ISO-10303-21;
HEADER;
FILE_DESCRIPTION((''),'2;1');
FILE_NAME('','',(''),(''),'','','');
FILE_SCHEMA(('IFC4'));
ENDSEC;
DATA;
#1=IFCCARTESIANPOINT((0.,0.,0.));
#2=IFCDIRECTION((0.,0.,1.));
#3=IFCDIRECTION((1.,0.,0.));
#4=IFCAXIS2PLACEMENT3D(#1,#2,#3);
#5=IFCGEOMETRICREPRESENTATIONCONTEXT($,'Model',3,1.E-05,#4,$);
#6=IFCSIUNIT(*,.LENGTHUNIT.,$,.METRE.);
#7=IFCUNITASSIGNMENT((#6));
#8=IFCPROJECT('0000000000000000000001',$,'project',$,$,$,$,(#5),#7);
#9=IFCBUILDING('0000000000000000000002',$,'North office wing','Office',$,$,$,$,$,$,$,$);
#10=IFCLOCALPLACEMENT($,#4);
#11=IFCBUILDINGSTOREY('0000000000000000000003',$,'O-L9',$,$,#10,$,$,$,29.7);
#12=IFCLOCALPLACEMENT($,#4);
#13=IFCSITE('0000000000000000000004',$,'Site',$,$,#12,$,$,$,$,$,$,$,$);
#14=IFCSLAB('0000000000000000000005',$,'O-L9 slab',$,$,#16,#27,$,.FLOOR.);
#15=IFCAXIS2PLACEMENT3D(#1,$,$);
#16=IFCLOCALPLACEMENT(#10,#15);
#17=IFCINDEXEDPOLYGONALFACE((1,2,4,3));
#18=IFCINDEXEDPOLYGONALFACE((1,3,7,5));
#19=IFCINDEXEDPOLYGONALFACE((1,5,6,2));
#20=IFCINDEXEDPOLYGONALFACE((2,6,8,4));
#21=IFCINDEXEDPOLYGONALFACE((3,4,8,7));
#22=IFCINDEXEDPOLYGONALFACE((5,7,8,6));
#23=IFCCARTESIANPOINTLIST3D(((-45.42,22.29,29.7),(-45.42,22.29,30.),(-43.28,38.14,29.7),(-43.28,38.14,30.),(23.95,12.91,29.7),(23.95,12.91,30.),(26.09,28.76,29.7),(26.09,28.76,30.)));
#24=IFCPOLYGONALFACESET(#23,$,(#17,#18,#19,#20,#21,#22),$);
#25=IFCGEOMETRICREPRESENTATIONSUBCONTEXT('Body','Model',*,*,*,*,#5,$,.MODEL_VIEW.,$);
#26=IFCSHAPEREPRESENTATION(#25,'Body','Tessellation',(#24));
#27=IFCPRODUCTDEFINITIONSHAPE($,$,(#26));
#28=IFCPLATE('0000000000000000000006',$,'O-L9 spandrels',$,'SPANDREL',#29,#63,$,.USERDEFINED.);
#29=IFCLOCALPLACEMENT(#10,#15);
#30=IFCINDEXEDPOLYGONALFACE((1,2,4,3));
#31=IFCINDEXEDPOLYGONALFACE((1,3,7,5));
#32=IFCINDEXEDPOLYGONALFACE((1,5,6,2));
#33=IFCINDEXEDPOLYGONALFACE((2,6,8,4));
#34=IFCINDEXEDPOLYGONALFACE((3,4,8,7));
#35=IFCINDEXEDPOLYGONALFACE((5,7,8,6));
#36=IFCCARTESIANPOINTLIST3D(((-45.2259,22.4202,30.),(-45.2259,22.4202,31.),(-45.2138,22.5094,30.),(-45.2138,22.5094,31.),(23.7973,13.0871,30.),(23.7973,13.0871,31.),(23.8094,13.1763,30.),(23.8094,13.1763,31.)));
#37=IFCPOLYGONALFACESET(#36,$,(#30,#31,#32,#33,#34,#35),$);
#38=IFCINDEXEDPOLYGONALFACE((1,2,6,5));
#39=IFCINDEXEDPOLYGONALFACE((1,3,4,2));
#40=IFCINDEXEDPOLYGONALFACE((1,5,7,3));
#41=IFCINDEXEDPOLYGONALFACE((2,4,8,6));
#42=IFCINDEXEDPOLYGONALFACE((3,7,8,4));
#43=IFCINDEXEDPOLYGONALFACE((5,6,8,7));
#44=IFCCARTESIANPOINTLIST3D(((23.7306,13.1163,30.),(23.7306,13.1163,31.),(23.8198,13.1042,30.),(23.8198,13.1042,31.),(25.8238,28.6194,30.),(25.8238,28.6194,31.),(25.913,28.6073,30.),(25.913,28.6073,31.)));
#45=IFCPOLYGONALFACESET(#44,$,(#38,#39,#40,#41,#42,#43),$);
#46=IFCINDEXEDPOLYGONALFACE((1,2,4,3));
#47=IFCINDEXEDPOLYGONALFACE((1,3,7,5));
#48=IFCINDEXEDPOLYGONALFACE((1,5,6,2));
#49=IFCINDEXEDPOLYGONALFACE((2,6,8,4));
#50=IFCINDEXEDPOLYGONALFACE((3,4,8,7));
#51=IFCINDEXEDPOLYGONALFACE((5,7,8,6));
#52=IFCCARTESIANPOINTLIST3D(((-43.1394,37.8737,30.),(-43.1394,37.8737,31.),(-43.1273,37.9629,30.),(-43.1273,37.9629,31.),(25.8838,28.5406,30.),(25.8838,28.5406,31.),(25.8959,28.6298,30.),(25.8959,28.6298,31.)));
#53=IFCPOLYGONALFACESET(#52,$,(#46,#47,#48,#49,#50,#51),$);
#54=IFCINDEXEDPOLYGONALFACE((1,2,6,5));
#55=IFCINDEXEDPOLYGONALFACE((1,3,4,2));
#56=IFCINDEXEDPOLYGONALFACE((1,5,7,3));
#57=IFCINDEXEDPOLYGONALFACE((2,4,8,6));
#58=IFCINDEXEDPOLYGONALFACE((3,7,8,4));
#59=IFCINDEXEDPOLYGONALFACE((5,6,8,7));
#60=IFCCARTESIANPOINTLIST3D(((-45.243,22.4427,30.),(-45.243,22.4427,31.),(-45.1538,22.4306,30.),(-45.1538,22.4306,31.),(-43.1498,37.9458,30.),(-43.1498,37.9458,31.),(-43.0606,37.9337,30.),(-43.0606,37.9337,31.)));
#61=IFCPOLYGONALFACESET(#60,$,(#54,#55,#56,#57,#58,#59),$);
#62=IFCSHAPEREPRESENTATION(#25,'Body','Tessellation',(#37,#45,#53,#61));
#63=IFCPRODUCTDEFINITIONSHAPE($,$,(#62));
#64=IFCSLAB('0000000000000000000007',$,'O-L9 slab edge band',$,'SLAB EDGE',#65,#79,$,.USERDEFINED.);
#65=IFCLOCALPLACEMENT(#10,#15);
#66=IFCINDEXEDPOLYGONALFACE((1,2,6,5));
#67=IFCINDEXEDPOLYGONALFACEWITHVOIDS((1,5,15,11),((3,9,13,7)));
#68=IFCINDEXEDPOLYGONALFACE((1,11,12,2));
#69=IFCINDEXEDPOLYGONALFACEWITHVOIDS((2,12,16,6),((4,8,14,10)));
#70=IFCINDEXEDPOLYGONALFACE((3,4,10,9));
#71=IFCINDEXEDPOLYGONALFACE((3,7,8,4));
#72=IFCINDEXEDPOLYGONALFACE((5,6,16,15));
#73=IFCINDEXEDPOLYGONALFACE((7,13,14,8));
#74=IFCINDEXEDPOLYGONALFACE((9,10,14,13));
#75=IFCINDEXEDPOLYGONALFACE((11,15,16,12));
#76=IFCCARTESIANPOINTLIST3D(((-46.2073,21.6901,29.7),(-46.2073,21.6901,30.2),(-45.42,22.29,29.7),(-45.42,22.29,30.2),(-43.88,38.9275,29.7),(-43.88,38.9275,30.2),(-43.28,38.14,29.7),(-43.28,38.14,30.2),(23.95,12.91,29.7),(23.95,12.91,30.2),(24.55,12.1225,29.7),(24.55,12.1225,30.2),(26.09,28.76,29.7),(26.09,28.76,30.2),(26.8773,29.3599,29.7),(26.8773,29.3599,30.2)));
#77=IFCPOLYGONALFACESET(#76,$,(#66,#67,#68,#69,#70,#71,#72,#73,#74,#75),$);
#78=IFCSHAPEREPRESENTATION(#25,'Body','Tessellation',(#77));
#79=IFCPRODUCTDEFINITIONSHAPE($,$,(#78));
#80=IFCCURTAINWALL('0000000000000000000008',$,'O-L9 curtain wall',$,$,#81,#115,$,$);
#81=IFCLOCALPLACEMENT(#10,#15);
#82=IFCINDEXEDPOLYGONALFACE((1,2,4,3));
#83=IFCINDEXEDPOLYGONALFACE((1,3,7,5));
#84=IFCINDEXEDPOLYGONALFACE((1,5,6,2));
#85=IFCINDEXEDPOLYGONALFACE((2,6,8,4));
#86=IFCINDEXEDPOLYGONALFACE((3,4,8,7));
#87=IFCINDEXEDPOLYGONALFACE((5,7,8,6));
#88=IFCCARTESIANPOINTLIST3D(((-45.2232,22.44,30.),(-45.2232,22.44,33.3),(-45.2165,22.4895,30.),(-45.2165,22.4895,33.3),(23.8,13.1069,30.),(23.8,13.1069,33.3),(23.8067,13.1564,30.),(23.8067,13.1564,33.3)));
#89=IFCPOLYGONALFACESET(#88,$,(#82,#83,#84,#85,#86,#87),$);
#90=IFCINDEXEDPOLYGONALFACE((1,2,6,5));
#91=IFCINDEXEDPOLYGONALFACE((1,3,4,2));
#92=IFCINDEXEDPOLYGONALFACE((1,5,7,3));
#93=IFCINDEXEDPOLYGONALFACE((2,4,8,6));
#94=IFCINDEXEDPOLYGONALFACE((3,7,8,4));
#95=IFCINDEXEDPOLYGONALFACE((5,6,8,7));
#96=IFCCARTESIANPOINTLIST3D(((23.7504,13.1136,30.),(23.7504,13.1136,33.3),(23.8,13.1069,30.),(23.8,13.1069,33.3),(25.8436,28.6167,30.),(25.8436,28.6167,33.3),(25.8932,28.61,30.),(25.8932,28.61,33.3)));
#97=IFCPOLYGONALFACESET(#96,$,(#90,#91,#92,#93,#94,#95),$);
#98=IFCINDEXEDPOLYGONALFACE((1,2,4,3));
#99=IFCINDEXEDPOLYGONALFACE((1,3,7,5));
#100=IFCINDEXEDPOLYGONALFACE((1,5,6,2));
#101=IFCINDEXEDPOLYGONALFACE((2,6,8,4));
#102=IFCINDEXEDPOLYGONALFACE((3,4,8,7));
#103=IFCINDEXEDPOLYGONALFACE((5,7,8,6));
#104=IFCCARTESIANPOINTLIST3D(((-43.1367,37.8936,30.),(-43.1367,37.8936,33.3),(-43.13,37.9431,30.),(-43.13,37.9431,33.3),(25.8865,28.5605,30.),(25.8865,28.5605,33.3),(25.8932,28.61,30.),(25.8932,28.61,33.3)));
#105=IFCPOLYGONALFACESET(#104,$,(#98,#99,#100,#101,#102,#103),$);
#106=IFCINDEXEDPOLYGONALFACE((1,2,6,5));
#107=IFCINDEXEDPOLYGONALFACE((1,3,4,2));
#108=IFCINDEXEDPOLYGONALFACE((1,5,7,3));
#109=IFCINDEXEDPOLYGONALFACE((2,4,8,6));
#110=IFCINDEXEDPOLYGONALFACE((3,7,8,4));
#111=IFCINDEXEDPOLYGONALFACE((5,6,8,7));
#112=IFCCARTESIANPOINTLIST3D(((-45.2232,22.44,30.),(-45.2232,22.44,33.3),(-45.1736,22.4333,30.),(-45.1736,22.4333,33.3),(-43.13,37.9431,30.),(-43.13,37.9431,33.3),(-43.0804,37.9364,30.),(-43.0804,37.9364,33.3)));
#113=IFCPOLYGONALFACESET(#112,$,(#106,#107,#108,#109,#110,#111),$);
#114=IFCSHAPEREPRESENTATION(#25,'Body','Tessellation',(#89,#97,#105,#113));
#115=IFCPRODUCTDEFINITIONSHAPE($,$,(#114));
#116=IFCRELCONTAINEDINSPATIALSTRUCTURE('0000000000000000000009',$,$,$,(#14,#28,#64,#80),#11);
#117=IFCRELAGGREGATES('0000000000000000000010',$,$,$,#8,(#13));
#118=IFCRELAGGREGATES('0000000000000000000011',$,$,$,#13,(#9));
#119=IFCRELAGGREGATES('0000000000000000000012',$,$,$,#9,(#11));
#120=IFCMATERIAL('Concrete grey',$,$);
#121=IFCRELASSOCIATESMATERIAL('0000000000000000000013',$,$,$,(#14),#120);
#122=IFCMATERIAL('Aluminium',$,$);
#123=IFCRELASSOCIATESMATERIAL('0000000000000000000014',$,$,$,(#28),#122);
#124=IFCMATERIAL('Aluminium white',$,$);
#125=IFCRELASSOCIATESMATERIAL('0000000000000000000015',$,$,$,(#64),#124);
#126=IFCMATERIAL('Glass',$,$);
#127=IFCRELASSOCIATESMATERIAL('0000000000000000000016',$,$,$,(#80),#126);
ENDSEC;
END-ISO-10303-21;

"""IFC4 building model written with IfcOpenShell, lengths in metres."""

from ifc_helpers import new_model, si_unit, frame, origin_with_axes, place, context, subcontext, project, spatial, polyline, outline, extrude, material, element, save


model = new_model("IFC4")

# Units and contexts
model_context = context("Model", 3, precision=1e-05, world=origin_with_axes())
body_context = subcontext(model_context, "Body", "Model", "MODEL_VIEW")
ifc_project = project(units=[si_unit("LENGTHUNIT", "METRE")], contexts=[model_context])

# Site, building, storey
site_placement = place(None, origin_with_axes())
site = spatial("IfcSite", under=ifc_project, at=site_placement, Name="Site")
building = spatial("IfcBuilding", under=site, Name="North office wing", Description="Office")
storey_placement = place(None, origin_with_axes())
storey = spatial("IfcBuildingStorey", under=building, at=storey_placement, Name="O-L9", Elevation=29.7)

# Shared definitions
ifc_material_1 = material(Name="Aluminium")

# Slab
ifc_material_2 = material(Name="Concrete grey")
slab_1_placement = place(storey_placement, origin_with_axes())
element("IfcSlab", 1, at=slab_1_placement, inside=storey, material=ifc_material_2, Name="O-L9 slab", PredefinedType="FLOOR", context=body_context, shape_type="SweptSolid", body=[
    extrude(outline(polyline([(-45.42, 22.29), (23.95, 12.91), (26.09, 28.76), (-43.28, 38.14), (-45.42, 22.29)])), frame((0.0, 0.0, 29.7), z_axis=(0.0, 0.0, 1.0), x_axis=(1.0, 0.0, 0.0)), (0.0, 0.0, 1.0), 0.3),
])

# Plate
plate_placement = place(storey_placement, origin_with_axes())
element("IfcPlate", 2, at=plate_placement, inside=storey, material=ifc_material_1, Name="O-L9 spandrels", ObjectType="SPANDREL", PredefinedType="USERDEFINED", context=body_context, shape_type="SweptSolid", body=[
    extrude(outline(polyline([(-45.2259, 22.4202), (23.7973, 13.0871), (23.8094, 13.1763), (-45.2138, 22.5094), (-45.2259, 22.4202)])), frame((0.0, 0.0, 30.0), z_axis=(0.0, 0.0, 1.0), x_axis=(1.0, 0.0, 0.0)), (0.0, 0.0, 1.0), 1.0),
    extrude(outline(polyline([(23.8198, 13.1042), (25.913, 28.6073), (25.8238, 28.6194), (23.7306, 13.1163), (23.8198, 13.1042)])), frame((0.0, 0.0, 30.0), z_axis=(0.0, 0.0, 1.0), x_axis=(1.0, 0.0, 0.0)), (0.0, 0.0, 1.0), 1.0),
    extrude(outline(polyline([(25.8959, 28.6298), (-43.1273, 37.9629), (-43.1394, 37.8737), (25.8838, 28.5406), (25.8959, 28.6298)])), frame((0.0, 0.0, 30.0), z_axis=(0.0, 0.0, 1.0), x_axis=(1.0, 0.0, 0.0)), (0.0, 0.0, 1.0), 1.0),
    extrude(outline(polyline([(-43.1498, 37.9458), (-45.243, 22.4427), (-45.1538, 22.4306), (-43.0606, 37.9337), (-43.1498, 37.9458)])), frame((0.0, 0.0, 30.0), z_axis=(0.0, 0.0, 1.0), x_axis=(1.0, 0.0, 0.0)), (0.0, 0.0, 1.0), 1.0),
])

# Slab
ifc_material_3 = material(Name="Aluminium white")
slab_2_placement = place(storey_placement, origin_with_axes())
element("IfcSlab", 3, at=slab_2_placement, inside=storey, material=ifc_material_3, Name="O-L9 slab edge band", ObjectType="SLAB EDGE", PredefinedType="USERDEFINED", context=body_context, shape_type="SweptSolid", body=[
    extrude(outline(polyline([(-46.2073, 21.6901), (24.55, 12.1225), (26.8773, 29.3599), (-43.88, 38.9275), (-46.2073, 21.6901)]), holes=[polyline([(-45.42, 22.29), (23.95, 12.91), (26.09, 28.76), (-43.28, 38.14), (-45.42, 22.29)])]), frame((0.0, 0.0, 29.7), z_axis=(0.0, 0.0, 1.0), x_axis=(1.0, 0.0, 0.0)), (0.0, 0.0, 1.0), 0.5),
])

# Curtain wall
ifc_material_4 = material(Name="Glass")
curtain_wall_placement = place(storey_placement, origin_with_axes())
element("IfcCurtainWall", 4, at=curtain_wall_placement, inside=storey, material=ifc_material_4, Name="O-L9 curtain wall", context=body_context, shape_type="SweptSolid", body=[
    extrude(outline(polyline([(-45.2232, 22.44), (23.8, 13.1069), (23.8067, 13.1564), (-45.2165, 22.4895), (-45.2232, 22.44)])), frame((0.0, 0.0, 30.0), z_axis=(0.0, 0.0, 1.0), x_axis=(1.0, 0.0, 0.0)), (0.0, 0.0, 1.0), 3.3),
    extrude(outline(polyline([(23.8, 13.1069), (25.8932, 28.61), (25.8436, 28.6167), (23.7504, 13.1136), (23.8, 13.1069)])), frame((0.0, 0.0, 30.0), z_axis=(0.0, 0.0, 1.0), x_axis=(1.0, 0.0, 0.0)), (0.0, 0.0, 1.0), 3.3),
    extrude(outline(polyline([(25.8932, 28.61), (-43.13, 37.9431), (-43.1367, 37.8936), (25.8865, 28.5605), (25.8932, 28.61)])), frame((0.0, 0.0, 30.0), z_axis=(0.0, 0.0, 1.0), x_axis=(1.0, 0.0, 0.0)), (0.0, 0.0, 1.0), 3.3),
    extrude(outline(polyline([(-43.13, 37.9431), (-45.2232, 22.44), (-45.1736, 22.4333), (-43.0804, 37.9364), (-43.13, 37.9431)])), frame((0.0, 0.0, 30.0), z_axis=(0.0, 0.0, 1.0), x_axis=(1.0, 0.0, 0.0)), (0.0, 0.0, 1.0), 3.3),
])

save(model, "model.ifc")
